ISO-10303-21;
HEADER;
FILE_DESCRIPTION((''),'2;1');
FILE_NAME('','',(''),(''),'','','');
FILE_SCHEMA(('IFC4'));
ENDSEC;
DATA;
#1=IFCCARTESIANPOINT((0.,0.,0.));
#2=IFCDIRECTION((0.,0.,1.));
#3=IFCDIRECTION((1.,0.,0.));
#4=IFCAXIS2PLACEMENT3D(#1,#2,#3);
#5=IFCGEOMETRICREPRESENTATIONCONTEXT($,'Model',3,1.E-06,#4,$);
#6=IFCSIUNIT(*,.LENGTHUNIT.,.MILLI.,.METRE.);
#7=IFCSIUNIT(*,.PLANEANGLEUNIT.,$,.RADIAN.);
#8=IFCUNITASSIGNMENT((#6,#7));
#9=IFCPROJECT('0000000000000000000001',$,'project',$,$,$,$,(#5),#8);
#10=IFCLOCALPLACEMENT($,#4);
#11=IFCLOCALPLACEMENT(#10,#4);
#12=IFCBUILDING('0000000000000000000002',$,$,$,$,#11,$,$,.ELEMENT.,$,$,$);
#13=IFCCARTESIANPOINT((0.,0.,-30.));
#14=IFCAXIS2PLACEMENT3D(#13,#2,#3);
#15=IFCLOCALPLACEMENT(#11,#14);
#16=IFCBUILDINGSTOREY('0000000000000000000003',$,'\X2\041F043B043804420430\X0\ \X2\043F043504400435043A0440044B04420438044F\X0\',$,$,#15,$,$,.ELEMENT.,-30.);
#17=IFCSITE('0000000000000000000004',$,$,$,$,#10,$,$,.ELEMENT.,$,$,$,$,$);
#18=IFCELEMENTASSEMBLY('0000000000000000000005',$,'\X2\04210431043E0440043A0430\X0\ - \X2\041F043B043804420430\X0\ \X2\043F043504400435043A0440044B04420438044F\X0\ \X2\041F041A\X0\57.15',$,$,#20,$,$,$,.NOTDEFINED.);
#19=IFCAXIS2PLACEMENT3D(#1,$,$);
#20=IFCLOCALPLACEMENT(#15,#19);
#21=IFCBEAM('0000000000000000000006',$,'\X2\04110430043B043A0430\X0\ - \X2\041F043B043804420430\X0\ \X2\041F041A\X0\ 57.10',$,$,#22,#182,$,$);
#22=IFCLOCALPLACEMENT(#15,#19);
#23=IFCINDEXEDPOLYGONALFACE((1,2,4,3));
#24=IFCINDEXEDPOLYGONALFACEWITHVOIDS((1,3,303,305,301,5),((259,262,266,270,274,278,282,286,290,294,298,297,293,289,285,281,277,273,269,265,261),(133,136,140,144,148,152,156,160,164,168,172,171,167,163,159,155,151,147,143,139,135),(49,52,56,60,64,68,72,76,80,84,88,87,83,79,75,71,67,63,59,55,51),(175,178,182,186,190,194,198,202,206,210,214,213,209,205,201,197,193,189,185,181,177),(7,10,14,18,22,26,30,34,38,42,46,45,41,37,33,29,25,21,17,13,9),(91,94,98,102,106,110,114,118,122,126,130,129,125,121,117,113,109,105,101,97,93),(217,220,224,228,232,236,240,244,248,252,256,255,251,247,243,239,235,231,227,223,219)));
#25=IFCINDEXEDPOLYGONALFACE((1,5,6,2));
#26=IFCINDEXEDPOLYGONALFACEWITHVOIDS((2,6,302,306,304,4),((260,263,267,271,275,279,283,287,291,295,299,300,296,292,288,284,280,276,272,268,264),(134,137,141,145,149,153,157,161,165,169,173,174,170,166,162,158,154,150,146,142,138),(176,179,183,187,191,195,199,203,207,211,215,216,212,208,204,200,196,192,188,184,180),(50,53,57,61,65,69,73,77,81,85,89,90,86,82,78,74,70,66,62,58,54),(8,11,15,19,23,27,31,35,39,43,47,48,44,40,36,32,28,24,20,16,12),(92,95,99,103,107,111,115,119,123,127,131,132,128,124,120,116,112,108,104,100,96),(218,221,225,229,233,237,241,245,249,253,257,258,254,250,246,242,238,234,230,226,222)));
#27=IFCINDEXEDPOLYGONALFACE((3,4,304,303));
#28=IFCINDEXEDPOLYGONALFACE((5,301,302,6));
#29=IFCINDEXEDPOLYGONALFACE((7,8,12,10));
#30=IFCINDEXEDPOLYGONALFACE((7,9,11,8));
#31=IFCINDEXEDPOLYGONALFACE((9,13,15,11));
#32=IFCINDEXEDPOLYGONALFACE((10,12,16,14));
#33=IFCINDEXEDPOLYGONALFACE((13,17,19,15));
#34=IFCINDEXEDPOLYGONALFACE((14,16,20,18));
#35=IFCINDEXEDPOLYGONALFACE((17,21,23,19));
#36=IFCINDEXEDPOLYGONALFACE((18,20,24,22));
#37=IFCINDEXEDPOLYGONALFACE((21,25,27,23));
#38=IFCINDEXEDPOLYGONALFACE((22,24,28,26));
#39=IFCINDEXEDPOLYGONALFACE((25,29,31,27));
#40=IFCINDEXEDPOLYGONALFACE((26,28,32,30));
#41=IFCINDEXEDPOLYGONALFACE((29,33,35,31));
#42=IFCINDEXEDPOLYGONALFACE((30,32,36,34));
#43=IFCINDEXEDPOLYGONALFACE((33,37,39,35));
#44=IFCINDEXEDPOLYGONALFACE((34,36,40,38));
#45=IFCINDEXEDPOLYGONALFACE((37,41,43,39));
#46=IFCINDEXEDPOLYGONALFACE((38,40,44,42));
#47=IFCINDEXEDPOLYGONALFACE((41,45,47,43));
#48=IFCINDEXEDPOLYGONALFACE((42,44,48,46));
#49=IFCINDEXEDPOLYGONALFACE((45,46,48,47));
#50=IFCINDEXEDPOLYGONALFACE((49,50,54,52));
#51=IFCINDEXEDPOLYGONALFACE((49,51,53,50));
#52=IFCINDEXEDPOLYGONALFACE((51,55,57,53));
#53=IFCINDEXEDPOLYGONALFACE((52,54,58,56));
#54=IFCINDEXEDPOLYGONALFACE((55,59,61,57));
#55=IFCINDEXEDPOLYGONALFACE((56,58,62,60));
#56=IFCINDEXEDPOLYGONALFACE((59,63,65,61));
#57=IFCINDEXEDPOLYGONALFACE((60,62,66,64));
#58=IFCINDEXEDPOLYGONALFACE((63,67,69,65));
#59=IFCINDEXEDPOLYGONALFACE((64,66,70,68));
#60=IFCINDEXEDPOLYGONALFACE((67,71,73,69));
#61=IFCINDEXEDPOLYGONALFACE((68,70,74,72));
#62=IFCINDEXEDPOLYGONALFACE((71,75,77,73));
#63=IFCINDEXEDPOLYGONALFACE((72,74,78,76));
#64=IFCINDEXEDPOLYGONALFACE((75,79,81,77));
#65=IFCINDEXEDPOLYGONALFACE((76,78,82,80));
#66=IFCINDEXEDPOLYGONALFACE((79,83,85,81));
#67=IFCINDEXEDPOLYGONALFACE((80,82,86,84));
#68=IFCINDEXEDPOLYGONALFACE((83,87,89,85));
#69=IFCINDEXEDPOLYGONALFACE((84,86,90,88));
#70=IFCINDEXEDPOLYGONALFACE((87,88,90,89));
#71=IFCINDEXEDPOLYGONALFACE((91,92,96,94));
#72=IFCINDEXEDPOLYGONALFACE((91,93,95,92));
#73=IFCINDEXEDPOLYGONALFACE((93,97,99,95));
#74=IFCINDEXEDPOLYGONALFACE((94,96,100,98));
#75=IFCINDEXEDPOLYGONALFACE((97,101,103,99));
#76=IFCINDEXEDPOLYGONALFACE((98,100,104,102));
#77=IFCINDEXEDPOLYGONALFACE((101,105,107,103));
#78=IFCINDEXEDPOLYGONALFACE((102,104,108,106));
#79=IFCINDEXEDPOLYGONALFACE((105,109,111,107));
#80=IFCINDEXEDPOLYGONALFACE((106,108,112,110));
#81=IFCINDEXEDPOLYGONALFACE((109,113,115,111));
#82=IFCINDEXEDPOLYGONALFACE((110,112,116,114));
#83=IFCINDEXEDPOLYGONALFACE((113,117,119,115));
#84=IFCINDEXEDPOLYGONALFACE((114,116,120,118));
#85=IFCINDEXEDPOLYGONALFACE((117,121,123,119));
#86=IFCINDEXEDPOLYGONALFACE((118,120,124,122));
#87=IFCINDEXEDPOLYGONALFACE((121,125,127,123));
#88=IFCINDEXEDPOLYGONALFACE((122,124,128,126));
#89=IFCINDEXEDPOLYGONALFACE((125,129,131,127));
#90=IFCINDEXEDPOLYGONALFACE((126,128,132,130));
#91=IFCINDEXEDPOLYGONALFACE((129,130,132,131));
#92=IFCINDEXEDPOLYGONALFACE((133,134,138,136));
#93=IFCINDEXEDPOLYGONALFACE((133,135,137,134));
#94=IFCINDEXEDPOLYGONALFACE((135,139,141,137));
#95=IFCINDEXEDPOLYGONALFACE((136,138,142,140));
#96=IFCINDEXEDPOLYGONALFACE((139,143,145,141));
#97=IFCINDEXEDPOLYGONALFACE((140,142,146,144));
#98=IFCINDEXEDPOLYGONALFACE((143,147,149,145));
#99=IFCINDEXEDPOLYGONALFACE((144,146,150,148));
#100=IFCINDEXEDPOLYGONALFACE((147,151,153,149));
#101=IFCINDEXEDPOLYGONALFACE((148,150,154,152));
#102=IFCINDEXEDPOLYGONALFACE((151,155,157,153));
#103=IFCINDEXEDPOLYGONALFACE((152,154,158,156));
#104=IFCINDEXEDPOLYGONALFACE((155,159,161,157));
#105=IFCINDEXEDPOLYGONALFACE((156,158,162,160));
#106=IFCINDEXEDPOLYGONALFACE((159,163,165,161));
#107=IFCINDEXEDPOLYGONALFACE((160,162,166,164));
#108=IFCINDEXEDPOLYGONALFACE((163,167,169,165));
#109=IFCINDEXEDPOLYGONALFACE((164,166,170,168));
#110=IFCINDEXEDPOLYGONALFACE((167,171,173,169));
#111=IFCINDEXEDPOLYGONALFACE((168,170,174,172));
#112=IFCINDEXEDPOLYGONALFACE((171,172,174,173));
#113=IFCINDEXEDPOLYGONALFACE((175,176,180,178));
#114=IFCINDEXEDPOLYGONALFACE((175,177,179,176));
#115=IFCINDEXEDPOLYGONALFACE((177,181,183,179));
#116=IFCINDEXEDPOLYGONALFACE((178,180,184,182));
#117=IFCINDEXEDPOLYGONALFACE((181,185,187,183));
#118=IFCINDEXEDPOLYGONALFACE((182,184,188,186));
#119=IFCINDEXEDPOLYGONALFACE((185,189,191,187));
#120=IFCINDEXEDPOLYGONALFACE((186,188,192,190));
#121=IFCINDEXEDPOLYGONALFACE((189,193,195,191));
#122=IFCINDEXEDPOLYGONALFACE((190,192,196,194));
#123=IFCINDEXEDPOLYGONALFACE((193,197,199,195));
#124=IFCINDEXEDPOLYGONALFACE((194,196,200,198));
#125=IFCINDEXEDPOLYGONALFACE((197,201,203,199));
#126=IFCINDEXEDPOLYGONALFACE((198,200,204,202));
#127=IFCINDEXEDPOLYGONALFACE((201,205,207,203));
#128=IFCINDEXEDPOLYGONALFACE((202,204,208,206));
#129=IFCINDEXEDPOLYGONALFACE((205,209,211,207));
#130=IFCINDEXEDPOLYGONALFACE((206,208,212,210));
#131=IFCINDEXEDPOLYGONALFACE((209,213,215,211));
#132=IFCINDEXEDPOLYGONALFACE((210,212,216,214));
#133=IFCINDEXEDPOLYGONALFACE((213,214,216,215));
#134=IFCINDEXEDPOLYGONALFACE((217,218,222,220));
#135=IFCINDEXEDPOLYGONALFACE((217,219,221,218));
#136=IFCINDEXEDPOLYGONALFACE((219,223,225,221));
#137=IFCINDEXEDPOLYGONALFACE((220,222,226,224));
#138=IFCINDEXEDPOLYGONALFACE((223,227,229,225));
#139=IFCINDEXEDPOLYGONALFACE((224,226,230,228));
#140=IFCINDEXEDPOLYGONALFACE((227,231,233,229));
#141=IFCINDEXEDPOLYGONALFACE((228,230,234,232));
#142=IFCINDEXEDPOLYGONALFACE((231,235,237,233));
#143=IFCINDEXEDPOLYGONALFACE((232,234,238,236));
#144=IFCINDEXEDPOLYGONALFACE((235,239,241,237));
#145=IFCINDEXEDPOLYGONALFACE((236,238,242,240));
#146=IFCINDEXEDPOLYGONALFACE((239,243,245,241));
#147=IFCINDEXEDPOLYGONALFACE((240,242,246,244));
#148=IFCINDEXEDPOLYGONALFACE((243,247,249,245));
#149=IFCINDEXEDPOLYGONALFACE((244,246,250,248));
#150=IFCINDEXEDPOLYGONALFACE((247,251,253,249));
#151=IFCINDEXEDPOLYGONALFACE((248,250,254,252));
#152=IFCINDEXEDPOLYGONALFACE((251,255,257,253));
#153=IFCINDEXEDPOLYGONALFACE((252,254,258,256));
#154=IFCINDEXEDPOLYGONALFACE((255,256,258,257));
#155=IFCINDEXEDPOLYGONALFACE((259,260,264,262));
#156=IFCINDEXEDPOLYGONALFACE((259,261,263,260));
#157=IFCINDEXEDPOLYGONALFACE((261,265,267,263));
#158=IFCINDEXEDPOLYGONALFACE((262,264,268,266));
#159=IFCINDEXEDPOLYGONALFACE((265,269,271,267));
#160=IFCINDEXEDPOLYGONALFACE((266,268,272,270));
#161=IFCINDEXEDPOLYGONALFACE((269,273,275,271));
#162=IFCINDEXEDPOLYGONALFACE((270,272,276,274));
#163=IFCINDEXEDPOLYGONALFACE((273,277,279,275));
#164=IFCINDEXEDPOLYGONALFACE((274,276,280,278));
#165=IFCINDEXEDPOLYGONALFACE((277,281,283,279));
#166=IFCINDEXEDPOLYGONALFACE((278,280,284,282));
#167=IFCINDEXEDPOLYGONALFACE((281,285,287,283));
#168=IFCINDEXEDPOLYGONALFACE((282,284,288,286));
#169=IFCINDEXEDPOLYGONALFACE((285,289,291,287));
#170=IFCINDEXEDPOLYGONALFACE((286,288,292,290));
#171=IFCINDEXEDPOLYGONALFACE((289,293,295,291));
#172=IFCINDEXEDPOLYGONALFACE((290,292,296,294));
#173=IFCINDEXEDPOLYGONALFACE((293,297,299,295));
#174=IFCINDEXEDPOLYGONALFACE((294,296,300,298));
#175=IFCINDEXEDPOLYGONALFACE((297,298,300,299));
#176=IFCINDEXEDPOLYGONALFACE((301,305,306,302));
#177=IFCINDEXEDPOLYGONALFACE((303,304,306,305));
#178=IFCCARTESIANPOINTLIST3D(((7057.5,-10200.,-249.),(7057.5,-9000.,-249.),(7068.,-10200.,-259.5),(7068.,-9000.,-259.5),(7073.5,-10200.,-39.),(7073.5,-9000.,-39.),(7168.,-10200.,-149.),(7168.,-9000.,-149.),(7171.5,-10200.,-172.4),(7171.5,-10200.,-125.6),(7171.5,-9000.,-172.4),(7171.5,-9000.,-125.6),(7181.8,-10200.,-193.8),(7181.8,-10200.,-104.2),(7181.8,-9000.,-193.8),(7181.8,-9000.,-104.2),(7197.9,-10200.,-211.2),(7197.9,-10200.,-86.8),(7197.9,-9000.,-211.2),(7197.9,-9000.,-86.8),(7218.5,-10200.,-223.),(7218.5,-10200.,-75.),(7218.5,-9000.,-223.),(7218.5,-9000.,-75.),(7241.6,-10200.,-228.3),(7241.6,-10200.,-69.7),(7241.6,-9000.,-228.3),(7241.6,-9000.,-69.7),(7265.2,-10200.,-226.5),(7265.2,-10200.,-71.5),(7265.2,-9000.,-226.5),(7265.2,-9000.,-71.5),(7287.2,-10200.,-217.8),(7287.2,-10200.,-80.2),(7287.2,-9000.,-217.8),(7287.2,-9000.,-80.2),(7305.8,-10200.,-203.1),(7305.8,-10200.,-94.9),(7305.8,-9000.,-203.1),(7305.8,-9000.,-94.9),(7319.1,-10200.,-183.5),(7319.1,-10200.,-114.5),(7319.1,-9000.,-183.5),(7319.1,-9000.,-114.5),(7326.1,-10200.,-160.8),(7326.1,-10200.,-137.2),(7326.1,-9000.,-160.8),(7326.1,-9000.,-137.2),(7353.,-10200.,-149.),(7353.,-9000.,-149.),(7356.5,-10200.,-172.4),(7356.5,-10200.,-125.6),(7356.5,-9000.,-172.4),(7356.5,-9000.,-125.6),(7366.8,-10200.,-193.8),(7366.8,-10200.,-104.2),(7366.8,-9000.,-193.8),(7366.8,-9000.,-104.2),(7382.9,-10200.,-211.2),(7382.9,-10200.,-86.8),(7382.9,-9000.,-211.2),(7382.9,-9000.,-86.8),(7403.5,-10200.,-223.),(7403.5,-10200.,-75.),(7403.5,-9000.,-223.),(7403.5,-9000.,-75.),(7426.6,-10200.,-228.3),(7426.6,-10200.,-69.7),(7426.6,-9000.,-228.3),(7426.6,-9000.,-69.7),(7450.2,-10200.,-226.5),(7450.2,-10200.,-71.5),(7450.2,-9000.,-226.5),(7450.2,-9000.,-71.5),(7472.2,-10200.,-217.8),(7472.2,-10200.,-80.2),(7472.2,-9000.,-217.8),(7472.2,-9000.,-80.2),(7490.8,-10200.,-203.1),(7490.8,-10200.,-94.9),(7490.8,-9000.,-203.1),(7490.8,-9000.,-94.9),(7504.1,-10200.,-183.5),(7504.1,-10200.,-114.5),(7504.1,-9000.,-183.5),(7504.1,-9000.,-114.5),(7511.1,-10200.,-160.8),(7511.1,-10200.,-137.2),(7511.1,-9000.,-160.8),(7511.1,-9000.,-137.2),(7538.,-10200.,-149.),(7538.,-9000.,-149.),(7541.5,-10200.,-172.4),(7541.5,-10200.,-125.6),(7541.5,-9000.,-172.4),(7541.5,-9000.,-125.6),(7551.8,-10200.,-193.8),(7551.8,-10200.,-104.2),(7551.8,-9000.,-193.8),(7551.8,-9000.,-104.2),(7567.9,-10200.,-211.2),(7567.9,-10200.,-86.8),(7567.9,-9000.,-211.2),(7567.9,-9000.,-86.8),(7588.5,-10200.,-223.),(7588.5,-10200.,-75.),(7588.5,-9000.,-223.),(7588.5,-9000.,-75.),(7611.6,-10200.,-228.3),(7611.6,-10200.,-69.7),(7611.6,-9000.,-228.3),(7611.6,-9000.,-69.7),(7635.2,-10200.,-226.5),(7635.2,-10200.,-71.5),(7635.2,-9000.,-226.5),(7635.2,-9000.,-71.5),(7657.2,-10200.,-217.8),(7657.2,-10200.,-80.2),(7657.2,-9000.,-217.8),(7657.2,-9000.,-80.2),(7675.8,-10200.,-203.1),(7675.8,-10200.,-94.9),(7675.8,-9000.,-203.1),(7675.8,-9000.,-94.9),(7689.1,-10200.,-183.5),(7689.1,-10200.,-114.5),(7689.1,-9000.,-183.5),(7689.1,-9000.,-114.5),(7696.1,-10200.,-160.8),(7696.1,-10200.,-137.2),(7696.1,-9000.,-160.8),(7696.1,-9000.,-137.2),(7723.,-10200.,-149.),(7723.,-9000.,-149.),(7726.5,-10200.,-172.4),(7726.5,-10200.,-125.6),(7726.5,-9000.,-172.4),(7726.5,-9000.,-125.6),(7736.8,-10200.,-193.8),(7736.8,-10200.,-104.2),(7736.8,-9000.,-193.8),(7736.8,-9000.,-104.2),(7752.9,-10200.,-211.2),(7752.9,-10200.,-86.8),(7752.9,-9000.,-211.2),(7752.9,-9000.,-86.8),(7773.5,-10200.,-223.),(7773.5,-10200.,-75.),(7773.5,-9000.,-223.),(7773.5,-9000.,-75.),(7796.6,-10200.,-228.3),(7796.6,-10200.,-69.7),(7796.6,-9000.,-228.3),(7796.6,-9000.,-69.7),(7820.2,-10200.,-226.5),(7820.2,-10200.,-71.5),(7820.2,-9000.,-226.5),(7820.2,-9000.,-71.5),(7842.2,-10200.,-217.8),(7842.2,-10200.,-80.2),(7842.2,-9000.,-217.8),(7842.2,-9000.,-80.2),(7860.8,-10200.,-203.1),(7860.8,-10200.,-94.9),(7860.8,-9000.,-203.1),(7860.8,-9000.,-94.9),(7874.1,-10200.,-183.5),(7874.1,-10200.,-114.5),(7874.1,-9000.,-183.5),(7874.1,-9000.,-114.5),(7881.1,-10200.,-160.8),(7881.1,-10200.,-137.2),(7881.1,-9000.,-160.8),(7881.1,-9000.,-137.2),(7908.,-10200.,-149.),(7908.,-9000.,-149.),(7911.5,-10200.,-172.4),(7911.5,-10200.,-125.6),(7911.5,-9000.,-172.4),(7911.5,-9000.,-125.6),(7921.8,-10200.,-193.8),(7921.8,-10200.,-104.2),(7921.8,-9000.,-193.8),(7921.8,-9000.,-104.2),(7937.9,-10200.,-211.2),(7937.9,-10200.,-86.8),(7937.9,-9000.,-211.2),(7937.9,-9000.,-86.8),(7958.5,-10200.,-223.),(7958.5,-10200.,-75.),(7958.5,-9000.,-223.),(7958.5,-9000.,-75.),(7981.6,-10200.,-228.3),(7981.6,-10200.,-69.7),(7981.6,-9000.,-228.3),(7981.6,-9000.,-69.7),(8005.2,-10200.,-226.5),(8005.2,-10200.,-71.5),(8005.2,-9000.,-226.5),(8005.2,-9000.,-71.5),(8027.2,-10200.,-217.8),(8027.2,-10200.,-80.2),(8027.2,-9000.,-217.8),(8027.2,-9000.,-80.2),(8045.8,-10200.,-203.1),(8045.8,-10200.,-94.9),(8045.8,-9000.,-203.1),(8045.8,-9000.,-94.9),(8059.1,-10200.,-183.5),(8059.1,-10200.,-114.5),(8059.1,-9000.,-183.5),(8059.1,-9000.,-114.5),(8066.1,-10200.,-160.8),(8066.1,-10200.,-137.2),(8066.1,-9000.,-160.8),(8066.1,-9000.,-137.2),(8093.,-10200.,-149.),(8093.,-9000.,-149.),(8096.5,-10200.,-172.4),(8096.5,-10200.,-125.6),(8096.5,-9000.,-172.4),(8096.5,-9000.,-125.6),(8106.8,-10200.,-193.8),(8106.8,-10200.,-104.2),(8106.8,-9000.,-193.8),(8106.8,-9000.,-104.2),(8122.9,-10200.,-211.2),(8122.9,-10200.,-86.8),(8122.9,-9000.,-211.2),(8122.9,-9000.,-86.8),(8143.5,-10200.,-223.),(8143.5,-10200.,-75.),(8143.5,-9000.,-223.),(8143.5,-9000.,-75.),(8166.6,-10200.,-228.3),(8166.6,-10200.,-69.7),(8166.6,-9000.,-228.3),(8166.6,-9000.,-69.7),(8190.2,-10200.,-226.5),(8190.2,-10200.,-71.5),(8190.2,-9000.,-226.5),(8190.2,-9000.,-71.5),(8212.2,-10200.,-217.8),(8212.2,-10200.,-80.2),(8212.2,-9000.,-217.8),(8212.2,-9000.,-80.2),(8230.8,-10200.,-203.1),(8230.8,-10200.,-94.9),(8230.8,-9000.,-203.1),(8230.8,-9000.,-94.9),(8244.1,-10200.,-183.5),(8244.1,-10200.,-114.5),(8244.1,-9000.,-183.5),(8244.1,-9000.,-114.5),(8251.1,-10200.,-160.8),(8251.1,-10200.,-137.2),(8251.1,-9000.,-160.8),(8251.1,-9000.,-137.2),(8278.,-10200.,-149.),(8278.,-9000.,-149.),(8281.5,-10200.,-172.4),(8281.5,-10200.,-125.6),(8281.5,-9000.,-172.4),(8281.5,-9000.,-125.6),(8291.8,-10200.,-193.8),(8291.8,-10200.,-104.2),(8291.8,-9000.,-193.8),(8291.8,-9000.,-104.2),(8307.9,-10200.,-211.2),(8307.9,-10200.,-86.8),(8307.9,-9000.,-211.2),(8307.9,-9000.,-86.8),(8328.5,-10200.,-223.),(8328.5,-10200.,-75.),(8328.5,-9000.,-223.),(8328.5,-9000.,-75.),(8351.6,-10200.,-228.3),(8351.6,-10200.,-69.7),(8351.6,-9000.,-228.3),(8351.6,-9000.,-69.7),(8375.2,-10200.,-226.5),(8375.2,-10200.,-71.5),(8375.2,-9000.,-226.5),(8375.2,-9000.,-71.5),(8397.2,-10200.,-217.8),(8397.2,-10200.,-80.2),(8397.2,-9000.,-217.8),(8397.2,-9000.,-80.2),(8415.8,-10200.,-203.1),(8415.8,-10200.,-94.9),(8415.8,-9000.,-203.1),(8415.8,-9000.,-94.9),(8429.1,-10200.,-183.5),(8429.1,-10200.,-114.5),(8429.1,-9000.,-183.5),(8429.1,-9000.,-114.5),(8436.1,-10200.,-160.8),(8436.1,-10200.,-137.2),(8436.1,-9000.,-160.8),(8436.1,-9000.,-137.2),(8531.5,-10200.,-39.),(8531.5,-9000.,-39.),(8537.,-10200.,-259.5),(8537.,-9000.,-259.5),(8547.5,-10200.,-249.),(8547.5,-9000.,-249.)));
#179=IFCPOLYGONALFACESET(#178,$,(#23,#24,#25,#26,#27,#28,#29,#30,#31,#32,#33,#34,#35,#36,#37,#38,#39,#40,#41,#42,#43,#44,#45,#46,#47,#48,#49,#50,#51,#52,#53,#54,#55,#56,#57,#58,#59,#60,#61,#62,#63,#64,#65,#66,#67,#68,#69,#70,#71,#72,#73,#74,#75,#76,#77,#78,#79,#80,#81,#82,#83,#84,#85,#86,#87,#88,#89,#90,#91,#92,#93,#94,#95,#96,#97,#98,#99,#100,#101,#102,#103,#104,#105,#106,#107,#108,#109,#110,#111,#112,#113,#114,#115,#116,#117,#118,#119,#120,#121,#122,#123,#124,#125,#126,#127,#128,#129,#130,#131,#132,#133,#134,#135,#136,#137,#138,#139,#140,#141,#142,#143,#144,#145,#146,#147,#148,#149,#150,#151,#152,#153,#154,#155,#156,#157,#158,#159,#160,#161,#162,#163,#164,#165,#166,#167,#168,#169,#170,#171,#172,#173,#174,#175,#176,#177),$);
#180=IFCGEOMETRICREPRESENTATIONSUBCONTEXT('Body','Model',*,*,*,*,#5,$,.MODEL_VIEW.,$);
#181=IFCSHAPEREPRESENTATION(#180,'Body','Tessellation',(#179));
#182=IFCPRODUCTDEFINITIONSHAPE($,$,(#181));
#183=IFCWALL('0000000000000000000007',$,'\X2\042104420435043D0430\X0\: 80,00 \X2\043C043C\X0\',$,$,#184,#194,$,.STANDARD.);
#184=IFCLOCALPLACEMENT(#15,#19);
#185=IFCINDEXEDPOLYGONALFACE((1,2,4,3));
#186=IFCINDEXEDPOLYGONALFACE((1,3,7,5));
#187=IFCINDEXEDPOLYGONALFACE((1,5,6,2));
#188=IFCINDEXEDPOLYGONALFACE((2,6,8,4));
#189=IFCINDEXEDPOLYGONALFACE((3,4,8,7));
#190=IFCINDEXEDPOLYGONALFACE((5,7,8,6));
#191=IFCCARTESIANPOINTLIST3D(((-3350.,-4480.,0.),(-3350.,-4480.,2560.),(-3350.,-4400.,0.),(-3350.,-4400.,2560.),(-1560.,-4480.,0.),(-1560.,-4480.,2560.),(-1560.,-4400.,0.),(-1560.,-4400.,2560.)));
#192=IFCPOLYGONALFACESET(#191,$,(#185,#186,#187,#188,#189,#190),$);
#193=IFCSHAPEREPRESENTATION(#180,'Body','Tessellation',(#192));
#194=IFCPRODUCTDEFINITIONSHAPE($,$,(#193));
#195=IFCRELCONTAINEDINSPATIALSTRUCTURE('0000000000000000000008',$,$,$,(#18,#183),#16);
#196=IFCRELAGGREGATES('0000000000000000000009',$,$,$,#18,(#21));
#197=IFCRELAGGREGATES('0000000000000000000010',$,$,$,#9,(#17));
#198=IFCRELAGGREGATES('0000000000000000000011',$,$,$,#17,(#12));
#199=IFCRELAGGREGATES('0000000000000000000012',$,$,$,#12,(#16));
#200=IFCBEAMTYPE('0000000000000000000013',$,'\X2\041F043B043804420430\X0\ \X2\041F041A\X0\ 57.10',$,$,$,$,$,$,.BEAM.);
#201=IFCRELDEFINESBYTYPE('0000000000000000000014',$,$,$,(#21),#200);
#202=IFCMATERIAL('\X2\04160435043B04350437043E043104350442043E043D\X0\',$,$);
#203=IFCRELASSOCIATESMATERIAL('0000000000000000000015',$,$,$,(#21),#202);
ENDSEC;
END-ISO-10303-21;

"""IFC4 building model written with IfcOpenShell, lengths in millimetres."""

from ifc_helpers import new_model, si_unit, frame, frame_2d, origin_with_axes, place, context, subcontext, project, spatial, line, indexed_curve, circle_curve, outline, extrude, source, transform, mapped, material, type_object, element, aggregate, save


model = new_model("IFC4")

# Units and contexts
model_context = context("Model", 3, precision=1e-06, world=origin_with_axes())
body_context = subcontext(model_context, "Body", "Model", "MODEL_VIEW")
ifc_project = project(units=[si_unit("LENGTHUNIT", "METRE", prefix="MILLI"), si_unit("PLANEANGLEUNIT", "RADIAN")], contexts=[model_context])

# Site, building, storey
site_placement = place(None, origin_with_axes())
site = spatial("IfcSite", under=ifc_project, at=site_placement, CompositionType="ELEMENT")
building_placement = place(site_placement, origin_with_axes())
building = spatial("IfcBuilding", under=site, at=building_placement, CompositionType="ELEMENT")
storey_placement = place(building_placement, frame((0.0, 0.0, -30.0), z_axis=(0.0, 0.0, 1.0), x_axis=(1.0, 0.0, 0.0)))
storey = spatial("IfcBuildingStorey", under=building, at=storey_placement, Name="Плита перекрытия", CompositionType="ELEMENT", Elevation=-30.0)

# Element assembly, beam
ifc_material_1 = material(Name="Железобетон")
beam_type_1 = type_object("IfcBeamType", Name="Плита ПК 57.10", PredefinedType="BEAM")
shared_shape_1 = source(origin_with_axes(), body_context, "Body", "SweptSolid", [
    extrude(outline(indexed_curve([(-729.0, 0.0), (-745.0, -210.0), (-734.5, -220.5), (734.5, -220.5), (745.0, -210.0), (729.0, 0.0)], segments=[line(1, 2), line(2, 3), line(3, 4), line(4, 5), line(5, 6), line(6, 1)]), holes=[circle_curve(frame_2d((555.0, -110.0), x_axis=(1.0, 0.0)), 79.5), circle_curve(frame_2d((370.0, -110.0), x_axis=(1.0, 0.0)), 79.5), circle_curve(frame_2d((185.0, -110.0), x_axis=(1.0, 0.0)), 79.5), circle_curve(frame_2d((-555.0, -110.0), x_axis=(1.0, 0.0)), 79.5), circle_curve(frame_2d((-370.0, -110.0), x_axis=(1.0, 0.0)), 79.5), circle_curve(frame_2d((-185.0, -110.0), x_axis=(1.0, 0.0)), 79.5), circle_curve(frame_2d((0.0, -110.0), x_axis=(1.0, 0.0)), 79.5)]), origin_with_axes(), (0.0, 0.0, -1.0), 1200.0),
])
assembly_1_placement = place(storey_placement, frame((7802.5, -9750.0, -39.0), z_axis=(0.0, 0.0, 1.0), x_axis=(1.0, 0.0, 0.0)))
assembly_1 = element("IfcElementAssembly", 1, at=assembly_1_placement, inside=storey, Name="Сборка - Плита перекрытия ПК57.15", PredefinedType="NOTDEFINED")
beam_1_placement = place(assembly_1_placement, frame((0.0, 750.0, 0.0), z_axis=(0.0, 1.0, 0.0), x_axis=(-1.0, 0.0, 0.0)))
beam_1 = element("IfcBeam", 2, at=beam_1_placement, type_object=beam_type_1, material=ifc_material_1, Name="Балка - Плита ПК 57.10", context=body_context, shape_type="MappedRepresentation", body=[
    mapped(shared_shape_1, transform((0.0, 0.0, 0.0), x_axis=(1.0, 0.0, 0.0), y_axis=(0.0, 1.0, 0.0), z_axis=(0.0, 0.0, 1.0), scale=1.0)),
])
aggregate(assembly_1, [beam_1])

# Wall
wall_placement = place(storey_placement, frame((-3350.0, -4400.0, 0.0), z_axis=(0.0, 0.0, 1.0), x_axis=(1.0, 0.0, 0.0)))
element("IfcWall", 3, at=wall_placement, inside=storey, Name="Стена: 80,00 мм", PredefinedType="STANDARD", context=body_context, shape_type="SweptSolid", body=[
    extrude(outline(indexed_curve([(0.0, -80.0), (1790.0, -80.0), (1790.0, 0.0), (0.0, 0.0)], segments=[line(1, 2), line(2, 3), line(3, 4), line(4, 1)])), origin_with_axes(), (0.0, 0.0, 1.0), 2560.0),
])

save(model, "model.ifc")
